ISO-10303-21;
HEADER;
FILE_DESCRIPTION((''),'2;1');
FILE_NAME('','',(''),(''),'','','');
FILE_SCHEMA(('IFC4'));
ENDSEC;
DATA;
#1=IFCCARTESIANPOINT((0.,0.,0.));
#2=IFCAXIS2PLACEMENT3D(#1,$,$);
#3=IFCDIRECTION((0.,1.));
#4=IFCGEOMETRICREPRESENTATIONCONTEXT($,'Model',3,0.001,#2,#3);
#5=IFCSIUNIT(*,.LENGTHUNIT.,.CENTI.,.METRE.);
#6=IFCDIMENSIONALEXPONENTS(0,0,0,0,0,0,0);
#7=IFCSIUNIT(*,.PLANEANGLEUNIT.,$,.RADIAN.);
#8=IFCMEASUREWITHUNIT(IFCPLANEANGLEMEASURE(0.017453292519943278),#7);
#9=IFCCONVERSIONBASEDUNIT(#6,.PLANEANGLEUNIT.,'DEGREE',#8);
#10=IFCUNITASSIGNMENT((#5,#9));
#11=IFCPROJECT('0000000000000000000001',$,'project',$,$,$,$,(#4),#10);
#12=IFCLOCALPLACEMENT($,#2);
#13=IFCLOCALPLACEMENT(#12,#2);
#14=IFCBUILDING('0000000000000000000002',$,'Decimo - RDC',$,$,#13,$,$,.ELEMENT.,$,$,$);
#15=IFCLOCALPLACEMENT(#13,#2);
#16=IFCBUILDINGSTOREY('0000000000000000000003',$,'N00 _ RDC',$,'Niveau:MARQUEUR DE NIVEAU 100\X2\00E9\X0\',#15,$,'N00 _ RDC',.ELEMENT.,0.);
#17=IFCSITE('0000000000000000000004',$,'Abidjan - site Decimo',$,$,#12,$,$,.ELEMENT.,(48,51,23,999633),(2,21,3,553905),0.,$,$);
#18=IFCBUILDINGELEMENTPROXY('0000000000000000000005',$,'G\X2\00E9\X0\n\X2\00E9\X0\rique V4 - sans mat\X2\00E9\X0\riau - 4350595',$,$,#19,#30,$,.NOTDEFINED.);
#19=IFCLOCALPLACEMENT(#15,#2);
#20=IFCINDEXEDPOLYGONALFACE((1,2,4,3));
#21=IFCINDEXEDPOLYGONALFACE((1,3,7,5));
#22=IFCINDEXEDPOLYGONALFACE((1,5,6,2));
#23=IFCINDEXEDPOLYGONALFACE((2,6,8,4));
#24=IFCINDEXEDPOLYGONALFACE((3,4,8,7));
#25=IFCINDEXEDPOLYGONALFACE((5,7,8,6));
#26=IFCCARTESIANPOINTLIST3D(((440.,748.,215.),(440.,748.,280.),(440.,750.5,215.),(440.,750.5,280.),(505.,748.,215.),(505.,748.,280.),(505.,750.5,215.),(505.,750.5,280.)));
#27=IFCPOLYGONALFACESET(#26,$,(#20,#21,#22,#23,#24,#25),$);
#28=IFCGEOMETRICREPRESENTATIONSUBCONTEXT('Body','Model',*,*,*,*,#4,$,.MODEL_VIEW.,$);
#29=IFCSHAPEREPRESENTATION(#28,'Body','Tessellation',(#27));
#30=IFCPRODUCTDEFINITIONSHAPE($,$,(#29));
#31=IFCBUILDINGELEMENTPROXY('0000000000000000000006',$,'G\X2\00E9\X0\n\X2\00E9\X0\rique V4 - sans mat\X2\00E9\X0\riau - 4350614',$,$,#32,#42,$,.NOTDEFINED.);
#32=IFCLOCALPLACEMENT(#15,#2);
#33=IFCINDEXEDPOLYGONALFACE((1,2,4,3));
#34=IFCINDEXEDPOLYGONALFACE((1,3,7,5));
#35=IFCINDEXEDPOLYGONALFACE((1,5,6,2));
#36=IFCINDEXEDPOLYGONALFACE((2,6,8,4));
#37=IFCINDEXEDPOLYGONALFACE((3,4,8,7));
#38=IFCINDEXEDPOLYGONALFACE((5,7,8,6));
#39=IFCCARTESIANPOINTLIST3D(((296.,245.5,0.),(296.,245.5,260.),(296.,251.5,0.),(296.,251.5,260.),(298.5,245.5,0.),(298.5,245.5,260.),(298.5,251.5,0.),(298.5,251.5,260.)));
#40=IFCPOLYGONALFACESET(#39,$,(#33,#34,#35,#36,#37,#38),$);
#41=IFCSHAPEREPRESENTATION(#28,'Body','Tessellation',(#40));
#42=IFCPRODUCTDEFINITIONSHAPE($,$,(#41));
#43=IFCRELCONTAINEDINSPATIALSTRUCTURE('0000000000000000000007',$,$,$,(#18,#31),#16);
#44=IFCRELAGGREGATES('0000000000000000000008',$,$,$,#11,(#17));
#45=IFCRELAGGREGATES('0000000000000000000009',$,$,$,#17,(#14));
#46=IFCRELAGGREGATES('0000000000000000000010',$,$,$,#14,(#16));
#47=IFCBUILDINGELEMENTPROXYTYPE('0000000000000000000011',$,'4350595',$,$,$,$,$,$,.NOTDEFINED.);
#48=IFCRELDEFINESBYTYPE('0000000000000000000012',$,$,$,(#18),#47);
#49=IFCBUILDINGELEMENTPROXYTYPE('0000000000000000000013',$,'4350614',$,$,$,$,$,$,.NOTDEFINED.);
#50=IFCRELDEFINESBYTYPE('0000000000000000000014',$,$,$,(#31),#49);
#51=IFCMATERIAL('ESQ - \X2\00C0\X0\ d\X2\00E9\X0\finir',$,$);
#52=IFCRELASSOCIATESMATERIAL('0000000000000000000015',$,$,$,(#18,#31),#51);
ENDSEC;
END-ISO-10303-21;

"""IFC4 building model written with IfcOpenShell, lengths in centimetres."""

from ifc_helpers import new_model, entity, si_unit, converted_unit, direction, frame, frame_2d, origin, place, context, subcontext, project, spatial, rectangle, extrude, material, type_object, element, save


model = new_model("IFC4")

# Units and contexts
model_context = context("Model", 3, precision=0.001, world=origin(), true_north=direction((0.0, 1.0)))
body_context = subcontext(model_context, "Body", "Model", "MODEL_VIEW")
ifc_project = project(units=[si_unit("LENGTHUNIT", "METRE", prefix="CENTI"), converted_unit("PLANEANGLEUNIT", "DEGREE", entity("IfcPlaneAngleMeasure", 0.017453292519943278), si_unit("PLANEANGLEUNIT", "RADIAN"), dimensions=[0, 0, 0, 0, 0, 0, 0])], contexts=[model_context])

# Site, building, storey
site_placement = place(None, origin())
site = spatial("IfcSite", under=ifc_project, at=site_placement, Name="Abidjan - site Decimo", CompositionType="ELEMENT", RefLatitude=(48, 51, 23, 999633), RefLongitude=(2, 21, 3, 553905), RefElevation=0.0)
building_placement = place(site_placement, origin())
building = spatial("IfcBuilding", under=site, at=building_placement, Name="Decimo - RDC", CompositionType="ELEMENT")
storey_placement = place(building_placement, origin())
storey = spatial("IfcBuildingStorey", under=building, at=storey_placement, Name="N00 _ RDC", ObjectType="Niveau:MARQUEUR DE NIVEAU 100é", LongName="N00 _ RDC", CompositionType="ELEMENT", Elevation=0.0)

# Building element proxies
ifc_material_1 = material(Name="ESQ - À définir")
building_element_proxy_type_1 = type_object("IfcBuildingElementProxyType", Name="4350595", PredefinedType="NOTDEFINED")
proxy_1_placement = place(storey_placement, origin())
element("IfcBuildingElementProxy", 1, at=proxy_1_placement, inside=storey, type_object=building_element_proxy_type_1, material=ifc_material_1, Name="Générique V4 - sans matériau - 4350595", PredefinedType="NOTDEFINED", context=body_context, shape_type="SweptSolid", body=[
    extrude(rectangle(XDim=65.0, YDim=2.5, at=frame_2d((0.0, 0.0), x_axis=(1.0, 0.0))), frame((472.5, 749.25, 215.0)), (0.0, 0.0, 1.0), 65.0),
])
building_element_proxy_type_2 = type_object("IfcBuildingElementProxyType", Name="4350614", PredefinedType="NOTDEFINED")
proxy_2_placement = place(storey_placement, origin())
element("IfcBuildingElementProxy", 2, at=proxy_2_placement, inside=storey, type_object=building_element_proxy_type_2, material=ifc_material_1, Name="Générique V4 - sans matériau - 4350614", PredefinedType="NOTDEFINED", context=body_context, shape_type="SweptSolid", body=[
    extrude(rectangle(XDim=2.5, YDim=6.0, at=frame_2d((0.0, 0.0), x_axis=(1.0, 0.0))), frame((297.25, 248.5, 0.0)), (0.0, 0.0, 1.0), 260.0),
])

save(model, "model.ifc")
